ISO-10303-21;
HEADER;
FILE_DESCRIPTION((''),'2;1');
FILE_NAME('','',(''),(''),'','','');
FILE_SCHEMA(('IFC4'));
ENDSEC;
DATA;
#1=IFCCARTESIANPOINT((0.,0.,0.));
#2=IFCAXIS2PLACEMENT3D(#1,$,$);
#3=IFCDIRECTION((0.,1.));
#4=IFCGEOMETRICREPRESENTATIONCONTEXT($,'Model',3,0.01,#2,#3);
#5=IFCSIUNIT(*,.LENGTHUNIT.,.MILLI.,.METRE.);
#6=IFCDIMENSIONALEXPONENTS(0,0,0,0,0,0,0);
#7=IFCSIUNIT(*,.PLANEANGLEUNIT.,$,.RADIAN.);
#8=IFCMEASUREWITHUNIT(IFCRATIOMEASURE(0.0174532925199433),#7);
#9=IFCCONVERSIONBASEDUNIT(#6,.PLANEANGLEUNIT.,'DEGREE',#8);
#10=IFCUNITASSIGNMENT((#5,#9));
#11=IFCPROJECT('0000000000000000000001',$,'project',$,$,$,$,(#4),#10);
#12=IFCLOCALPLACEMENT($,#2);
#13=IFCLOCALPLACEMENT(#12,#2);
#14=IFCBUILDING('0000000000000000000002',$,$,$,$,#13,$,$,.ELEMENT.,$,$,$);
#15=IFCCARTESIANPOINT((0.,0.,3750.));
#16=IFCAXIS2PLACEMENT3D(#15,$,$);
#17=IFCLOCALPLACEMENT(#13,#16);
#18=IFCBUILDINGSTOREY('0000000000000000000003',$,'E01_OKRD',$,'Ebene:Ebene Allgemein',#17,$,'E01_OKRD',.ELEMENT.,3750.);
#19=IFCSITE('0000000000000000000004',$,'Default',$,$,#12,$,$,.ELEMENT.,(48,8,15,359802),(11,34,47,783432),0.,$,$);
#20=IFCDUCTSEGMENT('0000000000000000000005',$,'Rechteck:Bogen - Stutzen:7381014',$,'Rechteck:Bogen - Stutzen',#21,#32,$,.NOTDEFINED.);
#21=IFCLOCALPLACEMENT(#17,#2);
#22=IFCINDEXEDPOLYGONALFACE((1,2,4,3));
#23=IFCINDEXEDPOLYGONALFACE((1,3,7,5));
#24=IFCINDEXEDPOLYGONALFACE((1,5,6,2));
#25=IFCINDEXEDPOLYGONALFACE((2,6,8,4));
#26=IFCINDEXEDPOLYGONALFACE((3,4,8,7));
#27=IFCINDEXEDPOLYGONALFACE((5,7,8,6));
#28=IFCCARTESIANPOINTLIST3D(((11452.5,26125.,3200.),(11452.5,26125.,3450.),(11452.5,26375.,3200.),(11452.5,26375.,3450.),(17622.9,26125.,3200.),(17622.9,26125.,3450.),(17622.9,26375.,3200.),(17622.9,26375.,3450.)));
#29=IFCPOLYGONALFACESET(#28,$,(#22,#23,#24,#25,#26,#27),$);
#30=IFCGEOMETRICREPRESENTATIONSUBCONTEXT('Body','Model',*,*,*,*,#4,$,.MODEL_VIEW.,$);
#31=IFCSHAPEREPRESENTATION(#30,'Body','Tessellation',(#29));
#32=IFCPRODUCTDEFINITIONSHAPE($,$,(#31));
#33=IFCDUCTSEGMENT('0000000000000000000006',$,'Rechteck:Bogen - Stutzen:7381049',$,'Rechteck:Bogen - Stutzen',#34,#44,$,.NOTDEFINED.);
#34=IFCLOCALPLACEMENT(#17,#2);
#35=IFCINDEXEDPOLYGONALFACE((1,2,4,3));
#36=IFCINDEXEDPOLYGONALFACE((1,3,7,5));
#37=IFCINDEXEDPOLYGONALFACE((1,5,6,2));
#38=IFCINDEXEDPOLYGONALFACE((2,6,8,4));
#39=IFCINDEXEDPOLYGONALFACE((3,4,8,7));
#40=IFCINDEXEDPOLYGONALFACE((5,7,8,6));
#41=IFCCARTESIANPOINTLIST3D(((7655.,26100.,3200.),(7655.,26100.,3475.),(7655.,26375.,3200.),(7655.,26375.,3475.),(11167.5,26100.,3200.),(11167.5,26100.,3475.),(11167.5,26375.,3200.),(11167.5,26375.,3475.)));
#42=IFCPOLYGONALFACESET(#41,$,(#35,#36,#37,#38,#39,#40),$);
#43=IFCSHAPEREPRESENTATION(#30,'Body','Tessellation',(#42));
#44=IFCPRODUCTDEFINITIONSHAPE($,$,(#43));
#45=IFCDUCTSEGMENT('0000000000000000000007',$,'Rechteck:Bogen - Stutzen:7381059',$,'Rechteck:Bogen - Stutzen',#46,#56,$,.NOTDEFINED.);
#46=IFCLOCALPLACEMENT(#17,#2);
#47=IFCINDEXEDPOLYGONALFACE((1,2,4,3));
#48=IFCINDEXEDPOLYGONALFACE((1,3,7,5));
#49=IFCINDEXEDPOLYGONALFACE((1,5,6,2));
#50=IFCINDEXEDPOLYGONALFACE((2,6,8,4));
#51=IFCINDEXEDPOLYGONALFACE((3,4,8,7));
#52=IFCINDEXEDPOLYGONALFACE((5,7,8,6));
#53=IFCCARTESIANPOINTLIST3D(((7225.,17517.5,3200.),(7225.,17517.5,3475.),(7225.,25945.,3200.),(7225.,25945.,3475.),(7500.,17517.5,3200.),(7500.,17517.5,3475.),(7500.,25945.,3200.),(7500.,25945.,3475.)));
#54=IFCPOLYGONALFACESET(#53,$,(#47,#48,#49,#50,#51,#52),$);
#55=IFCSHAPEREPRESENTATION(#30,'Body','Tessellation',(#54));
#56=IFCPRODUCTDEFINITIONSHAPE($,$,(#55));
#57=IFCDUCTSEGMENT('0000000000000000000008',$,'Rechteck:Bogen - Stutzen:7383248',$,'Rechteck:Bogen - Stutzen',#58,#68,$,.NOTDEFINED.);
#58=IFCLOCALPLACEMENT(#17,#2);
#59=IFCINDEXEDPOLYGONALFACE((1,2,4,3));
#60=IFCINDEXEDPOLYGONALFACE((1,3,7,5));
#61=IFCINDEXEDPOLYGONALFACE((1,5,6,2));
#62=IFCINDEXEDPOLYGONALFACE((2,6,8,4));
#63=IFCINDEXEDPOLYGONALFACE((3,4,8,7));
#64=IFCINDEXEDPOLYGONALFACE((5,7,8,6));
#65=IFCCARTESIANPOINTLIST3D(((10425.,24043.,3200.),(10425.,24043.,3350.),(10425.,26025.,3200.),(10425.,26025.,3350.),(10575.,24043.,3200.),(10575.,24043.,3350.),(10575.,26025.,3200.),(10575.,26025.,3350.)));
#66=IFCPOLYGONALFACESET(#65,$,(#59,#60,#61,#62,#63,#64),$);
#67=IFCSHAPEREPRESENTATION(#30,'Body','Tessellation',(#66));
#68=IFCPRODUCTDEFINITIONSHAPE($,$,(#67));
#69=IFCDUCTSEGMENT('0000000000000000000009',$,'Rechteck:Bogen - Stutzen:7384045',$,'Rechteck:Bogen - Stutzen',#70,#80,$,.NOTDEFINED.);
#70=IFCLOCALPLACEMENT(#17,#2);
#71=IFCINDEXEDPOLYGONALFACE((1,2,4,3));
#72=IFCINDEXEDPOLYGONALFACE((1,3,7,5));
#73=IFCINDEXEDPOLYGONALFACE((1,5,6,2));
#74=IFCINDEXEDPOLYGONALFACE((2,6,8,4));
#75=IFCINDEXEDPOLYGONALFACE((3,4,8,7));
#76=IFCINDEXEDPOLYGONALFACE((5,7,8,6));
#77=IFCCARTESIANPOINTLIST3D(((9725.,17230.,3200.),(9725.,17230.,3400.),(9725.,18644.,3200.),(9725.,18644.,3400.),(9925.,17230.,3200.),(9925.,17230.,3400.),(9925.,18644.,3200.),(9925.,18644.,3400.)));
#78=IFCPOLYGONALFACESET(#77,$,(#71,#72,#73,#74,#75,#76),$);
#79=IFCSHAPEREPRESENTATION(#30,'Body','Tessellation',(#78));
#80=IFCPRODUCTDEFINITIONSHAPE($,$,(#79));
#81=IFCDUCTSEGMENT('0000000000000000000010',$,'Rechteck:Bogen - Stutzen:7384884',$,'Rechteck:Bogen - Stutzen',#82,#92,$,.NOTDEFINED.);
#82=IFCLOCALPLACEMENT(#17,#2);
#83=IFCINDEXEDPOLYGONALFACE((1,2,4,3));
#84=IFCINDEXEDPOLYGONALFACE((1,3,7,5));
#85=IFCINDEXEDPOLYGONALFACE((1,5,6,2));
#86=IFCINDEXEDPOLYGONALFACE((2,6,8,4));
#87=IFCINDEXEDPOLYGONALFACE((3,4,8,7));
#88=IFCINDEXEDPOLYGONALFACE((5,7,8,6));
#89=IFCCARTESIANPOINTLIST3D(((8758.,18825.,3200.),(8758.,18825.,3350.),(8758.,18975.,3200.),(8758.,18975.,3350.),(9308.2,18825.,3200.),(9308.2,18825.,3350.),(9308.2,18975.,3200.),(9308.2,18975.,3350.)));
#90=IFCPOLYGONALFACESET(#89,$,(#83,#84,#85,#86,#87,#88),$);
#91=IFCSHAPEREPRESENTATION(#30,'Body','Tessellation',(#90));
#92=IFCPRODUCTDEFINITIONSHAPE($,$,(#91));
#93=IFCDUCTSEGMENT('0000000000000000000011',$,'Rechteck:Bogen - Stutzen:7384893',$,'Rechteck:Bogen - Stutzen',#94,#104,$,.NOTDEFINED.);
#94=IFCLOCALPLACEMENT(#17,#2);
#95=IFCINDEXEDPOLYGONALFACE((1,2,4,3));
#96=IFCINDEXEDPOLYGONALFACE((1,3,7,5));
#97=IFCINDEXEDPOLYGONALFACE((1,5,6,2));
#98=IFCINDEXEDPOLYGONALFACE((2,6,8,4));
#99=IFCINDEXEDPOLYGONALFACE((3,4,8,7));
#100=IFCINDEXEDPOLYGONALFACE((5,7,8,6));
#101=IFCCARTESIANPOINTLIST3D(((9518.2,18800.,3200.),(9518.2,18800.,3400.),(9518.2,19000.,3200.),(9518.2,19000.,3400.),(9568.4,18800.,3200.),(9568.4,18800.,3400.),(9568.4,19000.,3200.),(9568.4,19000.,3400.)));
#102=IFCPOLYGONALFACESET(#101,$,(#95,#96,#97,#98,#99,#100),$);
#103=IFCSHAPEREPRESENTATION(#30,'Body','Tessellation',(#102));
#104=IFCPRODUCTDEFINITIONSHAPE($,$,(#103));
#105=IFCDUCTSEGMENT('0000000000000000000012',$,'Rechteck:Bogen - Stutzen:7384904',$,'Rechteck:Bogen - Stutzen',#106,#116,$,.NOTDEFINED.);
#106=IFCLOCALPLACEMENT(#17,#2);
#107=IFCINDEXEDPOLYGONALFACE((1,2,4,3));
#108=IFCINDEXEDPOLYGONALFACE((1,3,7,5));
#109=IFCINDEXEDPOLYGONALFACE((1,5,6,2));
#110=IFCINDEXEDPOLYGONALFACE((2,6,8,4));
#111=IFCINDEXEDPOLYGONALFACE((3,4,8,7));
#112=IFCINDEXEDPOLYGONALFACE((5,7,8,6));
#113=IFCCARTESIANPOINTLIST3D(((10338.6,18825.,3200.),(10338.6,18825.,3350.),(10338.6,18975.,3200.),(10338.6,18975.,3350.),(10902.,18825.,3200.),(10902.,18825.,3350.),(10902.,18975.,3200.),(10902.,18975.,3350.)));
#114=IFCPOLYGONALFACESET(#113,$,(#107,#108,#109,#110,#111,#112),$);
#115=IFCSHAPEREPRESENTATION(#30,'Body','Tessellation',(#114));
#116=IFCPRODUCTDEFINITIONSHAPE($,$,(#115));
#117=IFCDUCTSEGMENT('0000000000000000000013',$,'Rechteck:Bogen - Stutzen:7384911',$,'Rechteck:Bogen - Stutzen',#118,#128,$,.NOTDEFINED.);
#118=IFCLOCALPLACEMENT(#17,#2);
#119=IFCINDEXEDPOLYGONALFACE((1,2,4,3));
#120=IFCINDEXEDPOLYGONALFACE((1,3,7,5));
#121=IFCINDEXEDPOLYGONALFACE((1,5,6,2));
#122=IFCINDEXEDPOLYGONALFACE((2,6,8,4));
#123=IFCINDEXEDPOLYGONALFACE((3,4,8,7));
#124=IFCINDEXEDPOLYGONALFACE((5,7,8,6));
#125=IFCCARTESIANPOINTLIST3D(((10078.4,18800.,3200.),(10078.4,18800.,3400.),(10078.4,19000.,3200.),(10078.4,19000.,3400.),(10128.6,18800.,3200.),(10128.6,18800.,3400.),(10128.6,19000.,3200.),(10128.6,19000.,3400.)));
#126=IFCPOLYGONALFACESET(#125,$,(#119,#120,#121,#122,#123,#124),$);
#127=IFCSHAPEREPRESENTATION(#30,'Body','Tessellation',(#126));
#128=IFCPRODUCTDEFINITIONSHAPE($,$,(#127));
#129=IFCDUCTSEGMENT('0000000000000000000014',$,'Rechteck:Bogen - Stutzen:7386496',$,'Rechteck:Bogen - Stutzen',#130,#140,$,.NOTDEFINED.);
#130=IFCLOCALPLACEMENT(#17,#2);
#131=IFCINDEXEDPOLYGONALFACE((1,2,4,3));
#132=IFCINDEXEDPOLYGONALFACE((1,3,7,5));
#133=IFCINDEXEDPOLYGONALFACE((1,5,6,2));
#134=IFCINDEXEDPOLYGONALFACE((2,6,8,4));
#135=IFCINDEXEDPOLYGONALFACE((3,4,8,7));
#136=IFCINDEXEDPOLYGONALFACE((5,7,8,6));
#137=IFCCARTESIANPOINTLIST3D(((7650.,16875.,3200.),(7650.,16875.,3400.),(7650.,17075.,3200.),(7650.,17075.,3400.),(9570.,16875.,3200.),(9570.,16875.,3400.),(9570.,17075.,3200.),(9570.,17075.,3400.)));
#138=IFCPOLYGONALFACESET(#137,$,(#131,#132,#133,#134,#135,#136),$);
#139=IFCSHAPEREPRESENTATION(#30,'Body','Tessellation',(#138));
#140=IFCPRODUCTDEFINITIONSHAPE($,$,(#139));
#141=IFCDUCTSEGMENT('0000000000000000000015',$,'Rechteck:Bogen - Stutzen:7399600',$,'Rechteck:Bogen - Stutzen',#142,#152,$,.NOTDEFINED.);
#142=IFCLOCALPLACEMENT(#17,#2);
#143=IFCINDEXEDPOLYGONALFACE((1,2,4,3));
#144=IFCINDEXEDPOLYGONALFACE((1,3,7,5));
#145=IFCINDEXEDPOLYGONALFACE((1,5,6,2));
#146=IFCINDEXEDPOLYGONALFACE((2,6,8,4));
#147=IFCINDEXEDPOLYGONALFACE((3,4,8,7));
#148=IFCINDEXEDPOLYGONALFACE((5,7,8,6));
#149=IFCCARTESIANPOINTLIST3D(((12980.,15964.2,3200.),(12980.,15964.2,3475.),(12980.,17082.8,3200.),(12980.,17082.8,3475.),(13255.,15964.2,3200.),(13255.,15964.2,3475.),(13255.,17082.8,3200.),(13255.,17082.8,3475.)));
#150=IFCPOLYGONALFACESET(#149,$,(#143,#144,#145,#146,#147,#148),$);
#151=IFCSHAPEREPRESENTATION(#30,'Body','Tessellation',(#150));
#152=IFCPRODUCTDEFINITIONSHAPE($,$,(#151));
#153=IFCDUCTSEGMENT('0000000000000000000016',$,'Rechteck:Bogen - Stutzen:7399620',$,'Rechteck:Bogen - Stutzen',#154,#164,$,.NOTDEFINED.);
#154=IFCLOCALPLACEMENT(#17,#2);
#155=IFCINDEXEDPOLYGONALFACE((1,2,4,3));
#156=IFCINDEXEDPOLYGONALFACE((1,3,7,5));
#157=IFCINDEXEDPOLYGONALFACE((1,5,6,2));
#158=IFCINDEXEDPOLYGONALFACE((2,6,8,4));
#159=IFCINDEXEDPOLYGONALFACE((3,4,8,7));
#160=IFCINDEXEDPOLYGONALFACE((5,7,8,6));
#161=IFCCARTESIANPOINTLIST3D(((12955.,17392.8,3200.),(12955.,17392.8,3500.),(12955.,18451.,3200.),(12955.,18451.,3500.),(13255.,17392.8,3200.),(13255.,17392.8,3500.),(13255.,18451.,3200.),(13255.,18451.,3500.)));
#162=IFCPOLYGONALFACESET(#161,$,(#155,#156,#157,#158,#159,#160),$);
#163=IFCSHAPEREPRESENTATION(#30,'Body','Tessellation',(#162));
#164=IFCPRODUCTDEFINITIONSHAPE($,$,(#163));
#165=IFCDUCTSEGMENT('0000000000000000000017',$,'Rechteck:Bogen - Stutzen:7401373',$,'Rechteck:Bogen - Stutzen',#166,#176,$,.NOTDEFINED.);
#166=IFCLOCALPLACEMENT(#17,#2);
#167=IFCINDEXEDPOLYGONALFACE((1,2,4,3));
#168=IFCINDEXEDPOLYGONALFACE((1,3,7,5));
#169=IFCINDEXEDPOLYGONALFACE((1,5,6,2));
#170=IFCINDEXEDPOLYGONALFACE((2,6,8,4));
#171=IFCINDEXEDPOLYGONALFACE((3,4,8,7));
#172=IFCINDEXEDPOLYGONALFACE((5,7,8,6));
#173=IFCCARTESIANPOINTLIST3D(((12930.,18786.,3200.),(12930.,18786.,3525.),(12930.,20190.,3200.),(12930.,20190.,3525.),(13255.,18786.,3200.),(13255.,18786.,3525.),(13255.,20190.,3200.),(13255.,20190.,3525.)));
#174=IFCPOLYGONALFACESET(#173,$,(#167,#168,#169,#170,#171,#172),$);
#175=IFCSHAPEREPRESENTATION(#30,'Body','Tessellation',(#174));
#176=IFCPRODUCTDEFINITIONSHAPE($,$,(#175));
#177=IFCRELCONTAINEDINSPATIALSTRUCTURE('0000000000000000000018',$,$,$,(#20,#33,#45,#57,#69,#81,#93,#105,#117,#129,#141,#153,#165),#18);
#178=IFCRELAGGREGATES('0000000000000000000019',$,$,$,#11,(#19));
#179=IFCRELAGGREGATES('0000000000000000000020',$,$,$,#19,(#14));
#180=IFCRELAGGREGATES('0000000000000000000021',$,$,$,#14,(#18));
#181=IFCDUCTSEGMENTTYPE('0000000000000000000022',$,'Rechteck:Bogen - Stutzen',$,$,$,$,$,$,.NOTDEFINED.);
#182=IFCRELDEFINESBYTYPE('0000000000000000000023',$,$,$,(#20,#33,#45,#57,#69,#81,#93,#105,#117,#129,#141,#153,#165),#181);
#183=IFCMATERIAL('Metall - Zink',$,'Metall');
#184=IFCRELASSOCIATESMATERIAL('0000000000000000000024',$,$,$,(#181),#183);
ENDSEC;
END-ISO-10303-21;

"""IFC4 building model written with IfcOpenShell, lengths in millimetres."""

from ifc_helpers import new_model, entity, si_unit, converted_unit, direction, frame, frame_2d, origin, origin_2d_with_axis, place, context, subcontext, project, spatial, rectangle, extrude, material, type_object, element, save


model = new_model("IFC4")

# Units and contexts
model_context = context("Model", 3, precision=0.01, world=origin(), true_north=direction((0.0, 1.0)))
body_context = subcontext(model_context, "Body", "Model", "MODEL_VIEW")
ifc_project = project(units=[si_unit("LENGTHUNIT", "METRE", prefix="MILLI"), converted_unit("PLANEANGLEUNIT", "DEGREE", entity("IfcRatioMeasure", 0.0174532925199433), si_unit("PLANEANGLEUNIT", "RADIAN"), dimensions=[0, 0, 0, 0, 0, 0, 0])], contexts=[model_context])

# Site, building, storey
site_placement = place(None, origin())
site = spatial("IfcSite", under=ifc_project, at=site_placement, Name="Default", CompositionType="ELEMENT", RefLatitude=(48, 8, 15, 359802), RefLongitude=(11, 34, 47, 783432), RefElevation=0.0)
building_placement = place(site_placement, origin())
building = spatial("IfcBuilding", under=site, at=building_placement, CompositionType="ELEMENT")
storey_placement = place(building_placement, frame((0.0, 0.0, 3750.0)))
storey = spatial("IfcBuildingStorey", under=building, at=storey_placement, Name="E01_OKRD", ObjectType="Ebene:Ebene Allgemein", LongName="E01_OKRD", CompositionType="ELEMENT", Elevation=3750.0)

# Duct segments
ifc_material_1 = material(Name="Metall - Zink", Category="Metall")
duct_segment_type_1 = type_object("IfcDuctSegmentType", Name="Rechteck:Bogen - Stutzen", PredefinedType="NOTDEFINED", material=ifc_material_1)
duct_segment_1_placement = place(storey_placement, frame((11452.5, 26125.0, 3200.0)))
element("IfcDuctSegment", 1, at=duct_segment_1_placement, inside=storey, type_object=duct_segment_type_1, Name="Rechteck:Bogen - Stutzen:7381014", ObjectType="Rechteck:Bogen - Stutzen", PredefinedType="NOTDEFINED", context=body_context, shape_type="SweptSolid", body=[
    extrude(rectangle(XDim=6170.5, YDim=250.0, at=frame_2d((0.0, 0.0), x_axis=(1.0, 0.0))), frame((3085.2, 125.0, 0.0), z_axis=(0.0, 0.0, 1.0), x_axis=(-1.0, 0.0, 0.0)), (0.0, 0.0, 1.0), 250.0),
])
duct_segment_2_placement = place(storey_placement, frame((7655.0, 26100.0, 3200.0)))
element("IfcDuctSegment", 2, at=duct_segment_2_placement, inside=storey, type_object=duct_segment_type_1, Name="Rechteck:Bogen - Stutzen:7381049", ObjectType="Rechteck:Bogen - Stutzen", PredefinedType="NOTDEFINED", context=body_context, shape_type="SweptSolid", body=[
    extrude(rectangle(XDim=3512.5, YDim=275.0, at=frame_2d((0.0, 0.0), x_axis=(1.0, 0.0))), frame((1756.3, 137.5, 0.0)), (0.0, 0.0, 1.0), 275.0),
])
duct_segment_3_placement = place(storey_placement, frame((7225.0, 17517.5, 3200.0)))
element("IfcDuctSegment", 3, at=duct_segment_3_placement, inside=storey, type_object=duct_segment_type_1, Name="Rechteck:Bogen - Stutzen:7381059", ObjectType="Rechteck:Bogen - Stutzen", PredefinedType="NOTDEFINED", context=body_context, shape_type="SweptSolid", body=[
    extrude(rectangle(XDim=8427.5, YDim=275.0, at=frame_2d((0.0, 0.0), x_axis=(1.0, 0.0))), frame((137.5, 4213.8, 0.0), z_axis=(0.0, 0.0, 1.0), x_axis=(0.0, -1.0, 0.0)), (0.0, 0.0, 1.0), 275.0),
])
duct_segment_4_placement = place(storey_placement, frame((10425.0, 24043.0, 3200.0)))
element("IfcDuctSegment", 4, at=duct_segment_4_placement, inside=storey, type_object=duct_segment_type_1, Name="Rechteck:Bogen - Stutzen:7383248", ObjectType="Rechteck:Bogen - Stutzen", PredefinedType="NOTDEFINED", context=body_context, shape_type="SweptSolid", body=[
    extrude(rectangle(XDim=1982.0, YDim=150.0, at=origin_2d_with_axis()), frame((75.0, 991.0, 0.0), z_axis=(0.0, 0.0, 1.0), x_axis=(0.0, 1.0, 0.0)), (0.0, 0.0, 1.0), 150.0),
])
duct_segment_5_placement = place(storey_placement, frame((9725.0, 17230.0, 3200.0)))
element("IfcDuctSegment", 5, at=duct_segment_5_placement, inside=storey, type_object=duct_segment_type_1, Name="Rechteck:Bogen - Stutzen:7384045", ObjectType="Rechteck:Bogen - Stutzen", PredefinedType="NOTDEFINED", context=body_context, shape_type="SweptSolid", body=[
    extrude(rectangle(XDim=1414.0, YDim=200.0, at=frame_2d((0.0, 0.0), x_axis=(1.0, 0.0))), frame((100.0, 707.0, 0.0), z_axis=(0.0, 0.0, 1.0), x_axis=(0.0, 1.0, 0.0)), (0.0, 0.0, 1.0), 200.0),
])
duct_segment_6_placement = place(storey_placement, frame((8758.0, 18825.0, 3200.0)))
element("IfcDuctSegment", 6, at=duct_segment_6_placement, inside=storey, type_object=duct_segment_type_1, Name="Rechteck:Bogen - Stutzen:7384884", ObjectType="Rechteck:Bogen - Stutzen", PredefinedType="NOTDEFINED", context=body_context, shape_type="SweptSolid", body=[
    extrude(rectangle(XDim=550.2, YDim=150.0, at=frame_2d((0.0, 0.0), x_axis=(1.0, 0.0))), frame((275.1, 75.0, 0.0), z_axis=(0.0, 0.0, 1.0), x_axis=(-1.0, 0.0, 0.0)), (0.0, 0.0, 1.0), 150.0),
])
duct_segment_7_placement = place(storey_placement, frame((9518.2, 18800.0, 3200.0)))
element("IfcDuctSegment", 7, at=duct_segment_7_placement, inside=storey, type_object=duct_segment_type_1, Name="Rechteck:Bogen - Stutzen:7384893", ObjectType="Rechteck:Bogen - Stutzen", PredefinedType="NOTDEFINED", context=body_context, shape_type="SweptSolid", body=[
    extrude(rectangle(XDim=50.2, YDim=200.0, at=origin_2d_with_axis()), frame((25.1, 100.0, 0.0), z_axis=(0.0, 0.0, 1.0), x_axis=(-1.0, 0.0, 0.0)), (0.0, 0.0, 1.0), 200.0),
])
duct_segment_8_placement = place(storey_placement, frame((10338.6, 18825.0, 3200.0)))
element("IfcDuctSegment", 8, at=duct_segment_8_placement, inside=storey, type_object=duct_segment_type_1, Name="Rechteck:Bogen - Stutzen:7384904", ObjectType="Rechteck:Bogen - Stutzen", PredefinedType="NOTDEFINED", context=body_context, shape_type="SweptSolid", body=[
    extrude(rectangle(XDim=563.4, YDim=150.0, at=frame_2d((0.0, 0.0), x_axis=(1.0, 0.0))), frame((281.7, 75.0, 0.0)), (0.0, 0.0, 1.0), 150.0),
])
duct_segment_9_placement = place(storey_placement, frame((10078.4, 18800.0, 3200.0)))
element("IfcDuctSegment", 9, at=duct_segment_9_placement, inside=storey, type_object=duct_segment_type_1, Name="Rechteck:Bogen - Stutzen:7384911", ObjectType="Rechteck:Bogen - Stutzen", PredefinedType="NOTDEFINED", context=body_context, shape_type="SweptSolid", body=[
    extrude(rectangle(XDim=50.2, YDim=200.0, at=origin_2d_with_axis()), frame((25.1, 100.0, 0.0)), (0.0, 0.0, 1.0), 200.0),
])
duct_segment_10_placement = place(storey_placement, frame((7650.0, 16875.0, 3200.0)))
element("IfcDuctSegment", 10, at=duct_segment_10_placement, inside=storey, type_object=duct_segment_type_1, Name="Rechteck:Bogen - Stutzen:7386496", ObjectType="Rechteck:Bogen - Stutzen", PredefinedType="NOTDEFINED", context=body_context, shape_type="SweptSolid", body=[
    extrude(rectangle(XDim=1920.0, YDim=200.0, at=origin_2d_with_axis()), frame((960.0, 100.0, 0.0)), (0.0, 0.0, 1.0), 200.0),
])
duct_segment_11_placement = place(storey_placement, frame((12980.0, 15964.2, 3200.0)))
element("IfcDuctSegment", 11, at=duct_segment_11_placement, inside=storey, type_object=duct_segment_type_1, Name="Rechteck:Bogen - Stutzen:7399600", ObjectType="Rechteck:Bogen - Stutzen", PredefinedType="NOTDEFINED", context=body_context, shape_type="SweptSolid", body=[
    extrude(rectangle(XDim=1118.6, YDim=275.0, at=frame_2d((0.0, 0.0), x_axis=(1.0, 0.0))), frame((137.5, 559.3, 0.0), z_axis=(0.0, 0.0, 1.0), x_axis=(0.0, 1.0, 0.0)), (0.0, 0.0, 1.0), 275.0),
])
duct_segment_12_placement = place(storey_placement, frame((12955.0, 17392.8, 3200.0)))
element("IfcDuctSegment", 12, at=duct_segment_12_placement, inside=storey, type_object=duct_segment_type_1, Name="Rechteck:Bogen - Stutzen:7399620", ObjectType="Rechteck:Bogen - Stutzen", PredefinedType="NOTDEFINED", context=body_context, shape_type="SweptSolid", body=[
    extrude(rectangle(XDim=1058.2, YDim=300.0, at=frame_2d((0.0, 0.0), x_axis=(1.0, 0.0))), frame((150.0, 529.1, 0.0), z_axis=(0.0, 0.0, 1.0), x_axis=(0.0, 1.0, 0.0)), (0.0, 0.0, 1.0), 300.0),
])
duct_segment_13_placement = place(storey_placement, frame((12930.0, 18786.0, 3200.0)))
element("IfcDuctSegment", 13, at=duct_segment_13_placement, inside=storey, type_object=duct_segment_type_1, Name="Rechteck:Bogen - Stutzen:7401373", ObjectType="Rechteck:Bogen - Stutzen", PredefinedType="NOTDEFINED", context=body_context, shape_type="SweptSolid", body=[
    extrude(rectangle(XDim=1404.0, YDim=325.0, at=frame_2d((0.0, 0.0), x_axis=(1.0, 0.0))), frame((162.5, 702.0, 0.0), z_axis=(0.0, 0.0, 1.0), x_axis=(0.0, 1.0, 0.0)), (0.0, 0.0, 1.0), 325.0),
])

save(model, "model.ifc")
